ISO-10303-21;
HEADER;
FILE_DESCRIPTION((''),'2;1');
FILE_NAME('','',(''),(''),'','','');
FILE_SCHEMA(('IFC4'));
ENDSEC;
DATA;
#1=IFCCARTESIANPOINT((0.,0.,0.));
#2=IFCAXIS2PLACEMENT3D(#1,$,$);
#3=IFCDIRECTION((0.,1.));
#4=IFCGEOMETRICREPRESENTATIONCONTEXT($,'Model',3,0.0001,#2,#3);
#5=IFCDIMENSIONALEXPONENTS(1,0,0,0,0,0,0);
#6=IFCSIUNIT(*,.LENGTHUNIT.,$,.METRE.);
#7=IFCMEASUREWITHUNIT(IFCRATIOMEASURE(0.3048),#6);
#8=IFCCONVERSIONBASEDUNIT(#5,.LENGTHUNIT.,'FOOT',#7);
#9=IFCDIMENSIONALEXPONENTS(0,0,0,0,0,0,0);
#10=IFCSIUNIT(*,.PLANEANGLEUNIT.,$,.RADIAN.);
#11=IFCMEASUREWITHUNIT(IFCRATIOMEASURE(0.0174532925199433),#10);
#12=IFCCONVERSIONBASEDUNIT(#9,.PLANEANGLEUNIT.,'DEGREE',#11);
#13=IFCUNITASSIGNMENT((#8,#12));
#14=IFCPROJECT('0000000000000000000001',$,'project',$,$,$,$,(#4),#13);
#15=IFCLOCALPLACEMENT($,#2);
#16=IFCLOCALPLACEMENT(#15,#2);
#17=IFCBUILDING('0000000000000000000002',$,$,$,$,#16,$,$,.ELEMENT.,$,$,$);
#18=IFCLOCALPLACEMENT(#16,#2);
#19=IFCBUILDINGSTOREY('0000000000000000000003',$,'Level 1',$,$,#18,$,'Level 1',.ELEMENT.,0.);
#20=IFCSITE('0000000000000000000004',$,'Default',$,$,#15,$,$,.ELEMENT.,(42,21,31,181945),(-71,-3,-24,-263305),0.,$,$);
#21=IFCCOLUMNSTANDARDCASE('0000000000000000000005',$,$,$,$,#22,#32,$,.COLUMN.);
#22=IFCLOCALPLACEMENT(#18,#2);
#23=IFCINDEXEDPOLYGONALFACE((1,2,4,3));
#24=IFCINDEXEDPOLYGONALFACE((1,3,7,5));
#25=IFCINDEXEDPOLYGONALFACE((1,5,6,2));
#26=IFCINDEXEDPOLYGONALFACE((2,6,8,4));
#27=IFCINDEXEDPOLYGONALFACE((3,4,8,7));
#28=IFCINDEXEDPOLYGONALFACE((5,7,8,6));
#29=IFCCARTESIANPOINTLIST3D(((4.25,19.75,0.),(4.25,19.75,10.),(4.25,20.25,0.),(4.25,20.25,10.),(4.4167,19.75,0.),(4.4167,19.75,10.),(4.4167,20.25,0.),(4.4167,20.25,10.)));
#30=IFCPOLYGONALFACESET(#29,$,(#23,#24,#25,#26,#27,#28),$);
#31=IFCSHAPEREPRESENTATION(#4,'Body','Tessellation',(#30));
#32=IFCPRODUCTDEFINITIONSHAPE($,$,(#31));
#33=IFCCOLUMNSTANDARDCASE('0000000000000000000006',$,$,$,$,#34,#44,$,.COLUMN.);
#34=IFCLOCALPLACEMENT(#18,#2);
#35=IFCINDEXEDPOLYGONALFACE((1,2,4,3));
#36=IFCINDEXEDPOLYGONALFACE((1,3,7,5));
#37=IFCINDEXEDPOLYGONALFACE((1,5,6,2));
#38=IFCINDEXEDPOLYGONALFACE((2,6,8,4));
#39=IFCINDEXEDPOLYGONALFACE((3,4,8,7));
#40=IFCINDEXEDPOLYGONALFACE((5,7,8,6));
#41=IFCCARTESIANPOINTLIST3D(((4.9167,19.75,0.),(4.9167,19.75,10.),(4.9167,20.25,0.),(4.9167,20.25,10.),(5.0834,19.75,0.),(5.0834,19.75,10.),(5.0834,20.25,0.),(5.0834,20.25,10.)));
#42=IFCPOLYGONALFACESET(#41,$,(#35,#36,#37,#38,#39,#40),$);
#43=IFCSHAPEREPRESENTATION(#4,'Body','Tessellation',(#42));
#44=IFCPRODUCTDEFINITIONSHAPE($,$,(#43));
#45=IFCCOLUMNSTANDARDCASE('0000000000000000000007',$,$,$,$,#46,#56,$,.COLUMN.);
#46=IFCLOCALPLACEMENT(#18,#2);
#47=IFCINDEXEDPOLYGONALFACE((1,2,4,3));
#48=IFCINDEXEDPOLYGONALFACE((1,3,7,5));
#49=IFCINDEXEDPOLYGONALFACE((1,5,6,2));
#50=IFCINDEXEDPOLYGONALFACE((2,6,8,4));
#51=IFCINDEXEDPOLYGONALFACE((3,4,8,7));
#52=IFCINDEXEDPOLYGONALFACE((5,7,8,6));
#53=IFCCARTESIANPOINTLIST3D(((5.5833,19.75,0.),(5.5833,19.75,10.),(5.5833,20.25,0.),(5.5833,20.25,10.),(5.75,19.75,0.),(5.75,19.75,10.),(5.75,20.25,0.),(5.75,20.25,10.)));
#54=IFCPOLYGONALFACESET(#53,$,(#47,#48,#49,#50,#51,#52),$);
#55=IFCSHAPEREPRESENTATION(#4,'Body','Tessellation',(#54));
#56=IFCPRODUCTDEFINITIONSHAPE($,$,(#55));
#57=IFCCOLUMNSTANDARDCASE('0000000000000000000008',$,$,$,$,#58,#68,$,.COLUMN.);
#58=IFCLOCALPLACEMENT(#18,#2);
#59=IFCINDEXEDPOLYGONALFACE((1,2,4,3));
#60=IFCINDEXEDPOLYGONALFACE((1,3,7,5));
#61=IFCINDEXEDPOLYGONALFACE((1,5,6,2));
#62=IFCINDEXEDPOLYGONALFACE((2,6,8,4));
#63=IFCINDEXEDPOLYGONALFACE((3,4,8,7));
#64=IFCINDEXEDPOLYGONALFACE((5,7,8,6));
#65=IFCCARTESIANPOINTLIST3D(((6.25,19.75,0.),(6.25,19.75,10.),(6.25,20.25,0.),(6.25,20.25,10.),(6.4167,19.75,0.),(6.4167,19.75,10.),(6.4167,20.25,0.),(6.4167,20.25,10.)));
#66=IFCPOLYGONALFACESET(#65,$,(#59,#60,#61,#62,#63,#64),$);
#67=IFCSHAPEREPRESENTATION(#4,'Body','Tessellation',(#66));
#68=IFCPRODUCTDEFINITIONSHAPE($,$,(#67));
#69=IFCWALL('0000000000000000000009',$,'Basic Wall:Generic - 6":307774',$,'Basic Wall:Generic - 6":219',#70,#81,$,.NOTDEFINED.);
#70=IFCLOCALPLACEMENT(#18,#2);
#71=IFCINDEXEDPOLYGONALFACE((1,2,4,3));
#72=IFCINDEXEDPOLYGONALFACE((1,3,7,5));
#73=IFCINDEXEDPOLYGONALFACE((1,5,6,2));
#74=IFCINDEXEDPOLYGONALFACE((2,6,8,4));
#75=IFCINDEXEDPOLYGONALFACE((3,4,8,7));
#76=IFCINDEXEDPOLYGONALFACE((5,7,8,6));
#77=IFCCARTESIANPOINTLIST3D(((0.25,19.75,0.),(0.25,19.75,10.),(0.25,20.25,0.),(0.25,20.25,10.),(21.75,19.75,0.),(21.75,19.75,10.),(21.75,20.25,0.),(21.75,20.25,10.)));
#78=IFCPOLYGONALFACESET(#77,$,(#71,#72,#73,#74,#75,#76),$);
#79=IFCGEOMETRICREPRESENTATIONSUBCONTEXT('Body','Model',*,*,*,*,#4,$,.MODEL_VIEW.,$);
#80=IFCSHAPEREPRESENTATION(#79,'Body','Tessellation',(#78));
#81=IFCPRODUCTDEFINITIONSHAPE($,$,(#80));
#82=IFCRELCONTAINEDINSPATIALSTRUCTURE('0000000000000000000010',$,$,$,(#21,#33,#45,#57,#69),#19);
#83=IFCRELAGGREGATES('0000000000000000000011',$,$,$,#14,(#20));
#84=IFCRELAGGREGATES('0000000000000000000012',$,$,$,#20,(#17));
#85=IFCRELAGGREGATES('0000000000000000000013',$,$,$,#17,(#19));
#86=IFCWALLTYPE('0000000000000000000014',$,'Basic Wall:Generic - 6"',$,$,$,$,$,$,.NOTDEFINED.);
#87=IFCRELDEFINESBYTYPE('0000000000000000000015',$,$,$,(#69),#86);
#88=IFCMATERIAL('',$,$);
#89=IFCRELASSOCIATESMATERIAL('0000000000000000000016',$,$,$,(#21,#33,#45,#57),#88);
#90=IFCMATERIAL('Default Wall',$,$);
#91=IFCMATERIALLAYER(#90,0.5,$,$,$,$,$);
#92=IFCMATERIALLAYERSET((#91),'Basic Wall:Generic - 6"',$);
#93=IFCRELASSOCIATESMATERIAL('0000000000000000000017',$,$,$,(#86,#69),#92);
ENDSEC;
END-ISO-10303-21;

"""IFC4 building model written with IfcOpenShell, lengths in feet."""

from ifc_helpers import new_model, entity, si_unit, converted_unit, direction, frame, frame_2d, origin, place, context, subcontext, project, spatial, rectangle, extrude, material, layer, layer_set, layer_usage, type_object, element, save


model = new_model("IFC4")

# Units and contexts
model_context = context("Model", 3, precision=0.0001, world=origin(), true_north=direction((0.0, 1.0)))
body_context = subcontext(model_context, "Body", "Model", "MODEL_VIEW")
ifc_project = project(units=[converted_unit("LENGTHUNIT", "FOOT", entity("IfcRatioMeasure", 0.3048), si_unit("LENGTHUNIT", "METRE"), dimensions=[1, 0, 0, 0, 0, 0, 0]), converted_unit("PLANEANGLEUNIT", "DEGREE", entity("IfcRatioMeasure", 0.0174532925199433), si_unit("PLANEANGLEUNIT", "RADIAN"), dimensions=[0, 0, 0, 0, 0, 0, 0])], contexts=[model_context])

# Site, building, storey
site_placement = place(None, origin())
site = spatial("IfcSite", under=ifc_project, at=site_placement, Name="Default", CompositionType="ELEMENT", RefLatitude=(42, 21, 31, 181945), RefLongitude=(-71, -3, -24, -263305), RefElevation=0.0)
building_placement = place(site_placement, origin())
building = spatial("IfcBuilding", under=site, at=building_placement, CompositionType="ELEMENT")
storey_placement = place(building_placement, origin())
storey = spatial("IfcBuildingStorey", under=building, at=storey_placement, Name="Level 1", LongName="Level 1", CompositionType="ELEMENT", Elevation=0.0)

# Columns
ifc_material_1 = material(Name="")
wall_placement = place(storey_placement, frame((0.25, 20.0, 0.0)))
for number, where, z_axis, x_axis in (
    (1, (4.0833, 0.0, 0.0), (0.0, 0.0, 1.0), (1.0, 0.0, 0.0)),
    (2, (4.75, 0.0, 0.0), (0.0, 0.0, 1.0), (1.0, 0.0, 0.0)),
    (3, (5.4167, 0.0, 0.0), (0.0, 0.0, 1.0), (1.0, 0.0, 0.0)),
    (4, (6.0833, 0.0, 0.0), (0.0, 0.0, 1.0), (1.0, 0.0, 0.0)),
):
    element("IfcColumnStandardCase", number, at=place(wall_placement, frame(where, z_axis=z_axis, x_axis=x_axis)), inside=storey, material=ifc_material_1, PredefinedType="COLUMN", context=model_context, shape_type="SweptSolid", body=[
        extrude(rectangle(XDim=0.1667, YDim=0.5), origin(), (0.0, 0.0, 1.0), 10.0),
    ])

# Wall
ifc_material_2 = material(Name="Default Wall")
ifc_layer = layer(ifc_material_2, 0.5)
ifc_layer_set = layer_set([ifc_layer], Name="Basic Wall:Generic - 6\"")
ifc_layer_usage = layer_usage(ifc_layer_set, "AXIS2", "NEGATIVE", 0.25)
wall_type = type_object("IfcWallType", Name="Basic Wall:Generic - 6\"", PredefinedType="NOTDEFINED", material=ifc_layer_set)
element("IfcWall", 5, at=wall_placement, inside=storey, type_object=wall_type, material=ifc_layer_usage, Name="Basic Wall:Generic - 6\":307774", ObjectType="Basic Wall:Generic - 6\":219", PredefinedType="NOTDEFINED", context=body_context, shape_type="SweptSolid", body=[
    extrude(rectangle(XDim=21.5, YDim=0.5, at=frame_2d((10.75, 0.0), x_axis=(-1.0, 0.0))), origin(), (0.0, 0.0, 1.0), 10.0),
])

save(model, "model.ifc")
